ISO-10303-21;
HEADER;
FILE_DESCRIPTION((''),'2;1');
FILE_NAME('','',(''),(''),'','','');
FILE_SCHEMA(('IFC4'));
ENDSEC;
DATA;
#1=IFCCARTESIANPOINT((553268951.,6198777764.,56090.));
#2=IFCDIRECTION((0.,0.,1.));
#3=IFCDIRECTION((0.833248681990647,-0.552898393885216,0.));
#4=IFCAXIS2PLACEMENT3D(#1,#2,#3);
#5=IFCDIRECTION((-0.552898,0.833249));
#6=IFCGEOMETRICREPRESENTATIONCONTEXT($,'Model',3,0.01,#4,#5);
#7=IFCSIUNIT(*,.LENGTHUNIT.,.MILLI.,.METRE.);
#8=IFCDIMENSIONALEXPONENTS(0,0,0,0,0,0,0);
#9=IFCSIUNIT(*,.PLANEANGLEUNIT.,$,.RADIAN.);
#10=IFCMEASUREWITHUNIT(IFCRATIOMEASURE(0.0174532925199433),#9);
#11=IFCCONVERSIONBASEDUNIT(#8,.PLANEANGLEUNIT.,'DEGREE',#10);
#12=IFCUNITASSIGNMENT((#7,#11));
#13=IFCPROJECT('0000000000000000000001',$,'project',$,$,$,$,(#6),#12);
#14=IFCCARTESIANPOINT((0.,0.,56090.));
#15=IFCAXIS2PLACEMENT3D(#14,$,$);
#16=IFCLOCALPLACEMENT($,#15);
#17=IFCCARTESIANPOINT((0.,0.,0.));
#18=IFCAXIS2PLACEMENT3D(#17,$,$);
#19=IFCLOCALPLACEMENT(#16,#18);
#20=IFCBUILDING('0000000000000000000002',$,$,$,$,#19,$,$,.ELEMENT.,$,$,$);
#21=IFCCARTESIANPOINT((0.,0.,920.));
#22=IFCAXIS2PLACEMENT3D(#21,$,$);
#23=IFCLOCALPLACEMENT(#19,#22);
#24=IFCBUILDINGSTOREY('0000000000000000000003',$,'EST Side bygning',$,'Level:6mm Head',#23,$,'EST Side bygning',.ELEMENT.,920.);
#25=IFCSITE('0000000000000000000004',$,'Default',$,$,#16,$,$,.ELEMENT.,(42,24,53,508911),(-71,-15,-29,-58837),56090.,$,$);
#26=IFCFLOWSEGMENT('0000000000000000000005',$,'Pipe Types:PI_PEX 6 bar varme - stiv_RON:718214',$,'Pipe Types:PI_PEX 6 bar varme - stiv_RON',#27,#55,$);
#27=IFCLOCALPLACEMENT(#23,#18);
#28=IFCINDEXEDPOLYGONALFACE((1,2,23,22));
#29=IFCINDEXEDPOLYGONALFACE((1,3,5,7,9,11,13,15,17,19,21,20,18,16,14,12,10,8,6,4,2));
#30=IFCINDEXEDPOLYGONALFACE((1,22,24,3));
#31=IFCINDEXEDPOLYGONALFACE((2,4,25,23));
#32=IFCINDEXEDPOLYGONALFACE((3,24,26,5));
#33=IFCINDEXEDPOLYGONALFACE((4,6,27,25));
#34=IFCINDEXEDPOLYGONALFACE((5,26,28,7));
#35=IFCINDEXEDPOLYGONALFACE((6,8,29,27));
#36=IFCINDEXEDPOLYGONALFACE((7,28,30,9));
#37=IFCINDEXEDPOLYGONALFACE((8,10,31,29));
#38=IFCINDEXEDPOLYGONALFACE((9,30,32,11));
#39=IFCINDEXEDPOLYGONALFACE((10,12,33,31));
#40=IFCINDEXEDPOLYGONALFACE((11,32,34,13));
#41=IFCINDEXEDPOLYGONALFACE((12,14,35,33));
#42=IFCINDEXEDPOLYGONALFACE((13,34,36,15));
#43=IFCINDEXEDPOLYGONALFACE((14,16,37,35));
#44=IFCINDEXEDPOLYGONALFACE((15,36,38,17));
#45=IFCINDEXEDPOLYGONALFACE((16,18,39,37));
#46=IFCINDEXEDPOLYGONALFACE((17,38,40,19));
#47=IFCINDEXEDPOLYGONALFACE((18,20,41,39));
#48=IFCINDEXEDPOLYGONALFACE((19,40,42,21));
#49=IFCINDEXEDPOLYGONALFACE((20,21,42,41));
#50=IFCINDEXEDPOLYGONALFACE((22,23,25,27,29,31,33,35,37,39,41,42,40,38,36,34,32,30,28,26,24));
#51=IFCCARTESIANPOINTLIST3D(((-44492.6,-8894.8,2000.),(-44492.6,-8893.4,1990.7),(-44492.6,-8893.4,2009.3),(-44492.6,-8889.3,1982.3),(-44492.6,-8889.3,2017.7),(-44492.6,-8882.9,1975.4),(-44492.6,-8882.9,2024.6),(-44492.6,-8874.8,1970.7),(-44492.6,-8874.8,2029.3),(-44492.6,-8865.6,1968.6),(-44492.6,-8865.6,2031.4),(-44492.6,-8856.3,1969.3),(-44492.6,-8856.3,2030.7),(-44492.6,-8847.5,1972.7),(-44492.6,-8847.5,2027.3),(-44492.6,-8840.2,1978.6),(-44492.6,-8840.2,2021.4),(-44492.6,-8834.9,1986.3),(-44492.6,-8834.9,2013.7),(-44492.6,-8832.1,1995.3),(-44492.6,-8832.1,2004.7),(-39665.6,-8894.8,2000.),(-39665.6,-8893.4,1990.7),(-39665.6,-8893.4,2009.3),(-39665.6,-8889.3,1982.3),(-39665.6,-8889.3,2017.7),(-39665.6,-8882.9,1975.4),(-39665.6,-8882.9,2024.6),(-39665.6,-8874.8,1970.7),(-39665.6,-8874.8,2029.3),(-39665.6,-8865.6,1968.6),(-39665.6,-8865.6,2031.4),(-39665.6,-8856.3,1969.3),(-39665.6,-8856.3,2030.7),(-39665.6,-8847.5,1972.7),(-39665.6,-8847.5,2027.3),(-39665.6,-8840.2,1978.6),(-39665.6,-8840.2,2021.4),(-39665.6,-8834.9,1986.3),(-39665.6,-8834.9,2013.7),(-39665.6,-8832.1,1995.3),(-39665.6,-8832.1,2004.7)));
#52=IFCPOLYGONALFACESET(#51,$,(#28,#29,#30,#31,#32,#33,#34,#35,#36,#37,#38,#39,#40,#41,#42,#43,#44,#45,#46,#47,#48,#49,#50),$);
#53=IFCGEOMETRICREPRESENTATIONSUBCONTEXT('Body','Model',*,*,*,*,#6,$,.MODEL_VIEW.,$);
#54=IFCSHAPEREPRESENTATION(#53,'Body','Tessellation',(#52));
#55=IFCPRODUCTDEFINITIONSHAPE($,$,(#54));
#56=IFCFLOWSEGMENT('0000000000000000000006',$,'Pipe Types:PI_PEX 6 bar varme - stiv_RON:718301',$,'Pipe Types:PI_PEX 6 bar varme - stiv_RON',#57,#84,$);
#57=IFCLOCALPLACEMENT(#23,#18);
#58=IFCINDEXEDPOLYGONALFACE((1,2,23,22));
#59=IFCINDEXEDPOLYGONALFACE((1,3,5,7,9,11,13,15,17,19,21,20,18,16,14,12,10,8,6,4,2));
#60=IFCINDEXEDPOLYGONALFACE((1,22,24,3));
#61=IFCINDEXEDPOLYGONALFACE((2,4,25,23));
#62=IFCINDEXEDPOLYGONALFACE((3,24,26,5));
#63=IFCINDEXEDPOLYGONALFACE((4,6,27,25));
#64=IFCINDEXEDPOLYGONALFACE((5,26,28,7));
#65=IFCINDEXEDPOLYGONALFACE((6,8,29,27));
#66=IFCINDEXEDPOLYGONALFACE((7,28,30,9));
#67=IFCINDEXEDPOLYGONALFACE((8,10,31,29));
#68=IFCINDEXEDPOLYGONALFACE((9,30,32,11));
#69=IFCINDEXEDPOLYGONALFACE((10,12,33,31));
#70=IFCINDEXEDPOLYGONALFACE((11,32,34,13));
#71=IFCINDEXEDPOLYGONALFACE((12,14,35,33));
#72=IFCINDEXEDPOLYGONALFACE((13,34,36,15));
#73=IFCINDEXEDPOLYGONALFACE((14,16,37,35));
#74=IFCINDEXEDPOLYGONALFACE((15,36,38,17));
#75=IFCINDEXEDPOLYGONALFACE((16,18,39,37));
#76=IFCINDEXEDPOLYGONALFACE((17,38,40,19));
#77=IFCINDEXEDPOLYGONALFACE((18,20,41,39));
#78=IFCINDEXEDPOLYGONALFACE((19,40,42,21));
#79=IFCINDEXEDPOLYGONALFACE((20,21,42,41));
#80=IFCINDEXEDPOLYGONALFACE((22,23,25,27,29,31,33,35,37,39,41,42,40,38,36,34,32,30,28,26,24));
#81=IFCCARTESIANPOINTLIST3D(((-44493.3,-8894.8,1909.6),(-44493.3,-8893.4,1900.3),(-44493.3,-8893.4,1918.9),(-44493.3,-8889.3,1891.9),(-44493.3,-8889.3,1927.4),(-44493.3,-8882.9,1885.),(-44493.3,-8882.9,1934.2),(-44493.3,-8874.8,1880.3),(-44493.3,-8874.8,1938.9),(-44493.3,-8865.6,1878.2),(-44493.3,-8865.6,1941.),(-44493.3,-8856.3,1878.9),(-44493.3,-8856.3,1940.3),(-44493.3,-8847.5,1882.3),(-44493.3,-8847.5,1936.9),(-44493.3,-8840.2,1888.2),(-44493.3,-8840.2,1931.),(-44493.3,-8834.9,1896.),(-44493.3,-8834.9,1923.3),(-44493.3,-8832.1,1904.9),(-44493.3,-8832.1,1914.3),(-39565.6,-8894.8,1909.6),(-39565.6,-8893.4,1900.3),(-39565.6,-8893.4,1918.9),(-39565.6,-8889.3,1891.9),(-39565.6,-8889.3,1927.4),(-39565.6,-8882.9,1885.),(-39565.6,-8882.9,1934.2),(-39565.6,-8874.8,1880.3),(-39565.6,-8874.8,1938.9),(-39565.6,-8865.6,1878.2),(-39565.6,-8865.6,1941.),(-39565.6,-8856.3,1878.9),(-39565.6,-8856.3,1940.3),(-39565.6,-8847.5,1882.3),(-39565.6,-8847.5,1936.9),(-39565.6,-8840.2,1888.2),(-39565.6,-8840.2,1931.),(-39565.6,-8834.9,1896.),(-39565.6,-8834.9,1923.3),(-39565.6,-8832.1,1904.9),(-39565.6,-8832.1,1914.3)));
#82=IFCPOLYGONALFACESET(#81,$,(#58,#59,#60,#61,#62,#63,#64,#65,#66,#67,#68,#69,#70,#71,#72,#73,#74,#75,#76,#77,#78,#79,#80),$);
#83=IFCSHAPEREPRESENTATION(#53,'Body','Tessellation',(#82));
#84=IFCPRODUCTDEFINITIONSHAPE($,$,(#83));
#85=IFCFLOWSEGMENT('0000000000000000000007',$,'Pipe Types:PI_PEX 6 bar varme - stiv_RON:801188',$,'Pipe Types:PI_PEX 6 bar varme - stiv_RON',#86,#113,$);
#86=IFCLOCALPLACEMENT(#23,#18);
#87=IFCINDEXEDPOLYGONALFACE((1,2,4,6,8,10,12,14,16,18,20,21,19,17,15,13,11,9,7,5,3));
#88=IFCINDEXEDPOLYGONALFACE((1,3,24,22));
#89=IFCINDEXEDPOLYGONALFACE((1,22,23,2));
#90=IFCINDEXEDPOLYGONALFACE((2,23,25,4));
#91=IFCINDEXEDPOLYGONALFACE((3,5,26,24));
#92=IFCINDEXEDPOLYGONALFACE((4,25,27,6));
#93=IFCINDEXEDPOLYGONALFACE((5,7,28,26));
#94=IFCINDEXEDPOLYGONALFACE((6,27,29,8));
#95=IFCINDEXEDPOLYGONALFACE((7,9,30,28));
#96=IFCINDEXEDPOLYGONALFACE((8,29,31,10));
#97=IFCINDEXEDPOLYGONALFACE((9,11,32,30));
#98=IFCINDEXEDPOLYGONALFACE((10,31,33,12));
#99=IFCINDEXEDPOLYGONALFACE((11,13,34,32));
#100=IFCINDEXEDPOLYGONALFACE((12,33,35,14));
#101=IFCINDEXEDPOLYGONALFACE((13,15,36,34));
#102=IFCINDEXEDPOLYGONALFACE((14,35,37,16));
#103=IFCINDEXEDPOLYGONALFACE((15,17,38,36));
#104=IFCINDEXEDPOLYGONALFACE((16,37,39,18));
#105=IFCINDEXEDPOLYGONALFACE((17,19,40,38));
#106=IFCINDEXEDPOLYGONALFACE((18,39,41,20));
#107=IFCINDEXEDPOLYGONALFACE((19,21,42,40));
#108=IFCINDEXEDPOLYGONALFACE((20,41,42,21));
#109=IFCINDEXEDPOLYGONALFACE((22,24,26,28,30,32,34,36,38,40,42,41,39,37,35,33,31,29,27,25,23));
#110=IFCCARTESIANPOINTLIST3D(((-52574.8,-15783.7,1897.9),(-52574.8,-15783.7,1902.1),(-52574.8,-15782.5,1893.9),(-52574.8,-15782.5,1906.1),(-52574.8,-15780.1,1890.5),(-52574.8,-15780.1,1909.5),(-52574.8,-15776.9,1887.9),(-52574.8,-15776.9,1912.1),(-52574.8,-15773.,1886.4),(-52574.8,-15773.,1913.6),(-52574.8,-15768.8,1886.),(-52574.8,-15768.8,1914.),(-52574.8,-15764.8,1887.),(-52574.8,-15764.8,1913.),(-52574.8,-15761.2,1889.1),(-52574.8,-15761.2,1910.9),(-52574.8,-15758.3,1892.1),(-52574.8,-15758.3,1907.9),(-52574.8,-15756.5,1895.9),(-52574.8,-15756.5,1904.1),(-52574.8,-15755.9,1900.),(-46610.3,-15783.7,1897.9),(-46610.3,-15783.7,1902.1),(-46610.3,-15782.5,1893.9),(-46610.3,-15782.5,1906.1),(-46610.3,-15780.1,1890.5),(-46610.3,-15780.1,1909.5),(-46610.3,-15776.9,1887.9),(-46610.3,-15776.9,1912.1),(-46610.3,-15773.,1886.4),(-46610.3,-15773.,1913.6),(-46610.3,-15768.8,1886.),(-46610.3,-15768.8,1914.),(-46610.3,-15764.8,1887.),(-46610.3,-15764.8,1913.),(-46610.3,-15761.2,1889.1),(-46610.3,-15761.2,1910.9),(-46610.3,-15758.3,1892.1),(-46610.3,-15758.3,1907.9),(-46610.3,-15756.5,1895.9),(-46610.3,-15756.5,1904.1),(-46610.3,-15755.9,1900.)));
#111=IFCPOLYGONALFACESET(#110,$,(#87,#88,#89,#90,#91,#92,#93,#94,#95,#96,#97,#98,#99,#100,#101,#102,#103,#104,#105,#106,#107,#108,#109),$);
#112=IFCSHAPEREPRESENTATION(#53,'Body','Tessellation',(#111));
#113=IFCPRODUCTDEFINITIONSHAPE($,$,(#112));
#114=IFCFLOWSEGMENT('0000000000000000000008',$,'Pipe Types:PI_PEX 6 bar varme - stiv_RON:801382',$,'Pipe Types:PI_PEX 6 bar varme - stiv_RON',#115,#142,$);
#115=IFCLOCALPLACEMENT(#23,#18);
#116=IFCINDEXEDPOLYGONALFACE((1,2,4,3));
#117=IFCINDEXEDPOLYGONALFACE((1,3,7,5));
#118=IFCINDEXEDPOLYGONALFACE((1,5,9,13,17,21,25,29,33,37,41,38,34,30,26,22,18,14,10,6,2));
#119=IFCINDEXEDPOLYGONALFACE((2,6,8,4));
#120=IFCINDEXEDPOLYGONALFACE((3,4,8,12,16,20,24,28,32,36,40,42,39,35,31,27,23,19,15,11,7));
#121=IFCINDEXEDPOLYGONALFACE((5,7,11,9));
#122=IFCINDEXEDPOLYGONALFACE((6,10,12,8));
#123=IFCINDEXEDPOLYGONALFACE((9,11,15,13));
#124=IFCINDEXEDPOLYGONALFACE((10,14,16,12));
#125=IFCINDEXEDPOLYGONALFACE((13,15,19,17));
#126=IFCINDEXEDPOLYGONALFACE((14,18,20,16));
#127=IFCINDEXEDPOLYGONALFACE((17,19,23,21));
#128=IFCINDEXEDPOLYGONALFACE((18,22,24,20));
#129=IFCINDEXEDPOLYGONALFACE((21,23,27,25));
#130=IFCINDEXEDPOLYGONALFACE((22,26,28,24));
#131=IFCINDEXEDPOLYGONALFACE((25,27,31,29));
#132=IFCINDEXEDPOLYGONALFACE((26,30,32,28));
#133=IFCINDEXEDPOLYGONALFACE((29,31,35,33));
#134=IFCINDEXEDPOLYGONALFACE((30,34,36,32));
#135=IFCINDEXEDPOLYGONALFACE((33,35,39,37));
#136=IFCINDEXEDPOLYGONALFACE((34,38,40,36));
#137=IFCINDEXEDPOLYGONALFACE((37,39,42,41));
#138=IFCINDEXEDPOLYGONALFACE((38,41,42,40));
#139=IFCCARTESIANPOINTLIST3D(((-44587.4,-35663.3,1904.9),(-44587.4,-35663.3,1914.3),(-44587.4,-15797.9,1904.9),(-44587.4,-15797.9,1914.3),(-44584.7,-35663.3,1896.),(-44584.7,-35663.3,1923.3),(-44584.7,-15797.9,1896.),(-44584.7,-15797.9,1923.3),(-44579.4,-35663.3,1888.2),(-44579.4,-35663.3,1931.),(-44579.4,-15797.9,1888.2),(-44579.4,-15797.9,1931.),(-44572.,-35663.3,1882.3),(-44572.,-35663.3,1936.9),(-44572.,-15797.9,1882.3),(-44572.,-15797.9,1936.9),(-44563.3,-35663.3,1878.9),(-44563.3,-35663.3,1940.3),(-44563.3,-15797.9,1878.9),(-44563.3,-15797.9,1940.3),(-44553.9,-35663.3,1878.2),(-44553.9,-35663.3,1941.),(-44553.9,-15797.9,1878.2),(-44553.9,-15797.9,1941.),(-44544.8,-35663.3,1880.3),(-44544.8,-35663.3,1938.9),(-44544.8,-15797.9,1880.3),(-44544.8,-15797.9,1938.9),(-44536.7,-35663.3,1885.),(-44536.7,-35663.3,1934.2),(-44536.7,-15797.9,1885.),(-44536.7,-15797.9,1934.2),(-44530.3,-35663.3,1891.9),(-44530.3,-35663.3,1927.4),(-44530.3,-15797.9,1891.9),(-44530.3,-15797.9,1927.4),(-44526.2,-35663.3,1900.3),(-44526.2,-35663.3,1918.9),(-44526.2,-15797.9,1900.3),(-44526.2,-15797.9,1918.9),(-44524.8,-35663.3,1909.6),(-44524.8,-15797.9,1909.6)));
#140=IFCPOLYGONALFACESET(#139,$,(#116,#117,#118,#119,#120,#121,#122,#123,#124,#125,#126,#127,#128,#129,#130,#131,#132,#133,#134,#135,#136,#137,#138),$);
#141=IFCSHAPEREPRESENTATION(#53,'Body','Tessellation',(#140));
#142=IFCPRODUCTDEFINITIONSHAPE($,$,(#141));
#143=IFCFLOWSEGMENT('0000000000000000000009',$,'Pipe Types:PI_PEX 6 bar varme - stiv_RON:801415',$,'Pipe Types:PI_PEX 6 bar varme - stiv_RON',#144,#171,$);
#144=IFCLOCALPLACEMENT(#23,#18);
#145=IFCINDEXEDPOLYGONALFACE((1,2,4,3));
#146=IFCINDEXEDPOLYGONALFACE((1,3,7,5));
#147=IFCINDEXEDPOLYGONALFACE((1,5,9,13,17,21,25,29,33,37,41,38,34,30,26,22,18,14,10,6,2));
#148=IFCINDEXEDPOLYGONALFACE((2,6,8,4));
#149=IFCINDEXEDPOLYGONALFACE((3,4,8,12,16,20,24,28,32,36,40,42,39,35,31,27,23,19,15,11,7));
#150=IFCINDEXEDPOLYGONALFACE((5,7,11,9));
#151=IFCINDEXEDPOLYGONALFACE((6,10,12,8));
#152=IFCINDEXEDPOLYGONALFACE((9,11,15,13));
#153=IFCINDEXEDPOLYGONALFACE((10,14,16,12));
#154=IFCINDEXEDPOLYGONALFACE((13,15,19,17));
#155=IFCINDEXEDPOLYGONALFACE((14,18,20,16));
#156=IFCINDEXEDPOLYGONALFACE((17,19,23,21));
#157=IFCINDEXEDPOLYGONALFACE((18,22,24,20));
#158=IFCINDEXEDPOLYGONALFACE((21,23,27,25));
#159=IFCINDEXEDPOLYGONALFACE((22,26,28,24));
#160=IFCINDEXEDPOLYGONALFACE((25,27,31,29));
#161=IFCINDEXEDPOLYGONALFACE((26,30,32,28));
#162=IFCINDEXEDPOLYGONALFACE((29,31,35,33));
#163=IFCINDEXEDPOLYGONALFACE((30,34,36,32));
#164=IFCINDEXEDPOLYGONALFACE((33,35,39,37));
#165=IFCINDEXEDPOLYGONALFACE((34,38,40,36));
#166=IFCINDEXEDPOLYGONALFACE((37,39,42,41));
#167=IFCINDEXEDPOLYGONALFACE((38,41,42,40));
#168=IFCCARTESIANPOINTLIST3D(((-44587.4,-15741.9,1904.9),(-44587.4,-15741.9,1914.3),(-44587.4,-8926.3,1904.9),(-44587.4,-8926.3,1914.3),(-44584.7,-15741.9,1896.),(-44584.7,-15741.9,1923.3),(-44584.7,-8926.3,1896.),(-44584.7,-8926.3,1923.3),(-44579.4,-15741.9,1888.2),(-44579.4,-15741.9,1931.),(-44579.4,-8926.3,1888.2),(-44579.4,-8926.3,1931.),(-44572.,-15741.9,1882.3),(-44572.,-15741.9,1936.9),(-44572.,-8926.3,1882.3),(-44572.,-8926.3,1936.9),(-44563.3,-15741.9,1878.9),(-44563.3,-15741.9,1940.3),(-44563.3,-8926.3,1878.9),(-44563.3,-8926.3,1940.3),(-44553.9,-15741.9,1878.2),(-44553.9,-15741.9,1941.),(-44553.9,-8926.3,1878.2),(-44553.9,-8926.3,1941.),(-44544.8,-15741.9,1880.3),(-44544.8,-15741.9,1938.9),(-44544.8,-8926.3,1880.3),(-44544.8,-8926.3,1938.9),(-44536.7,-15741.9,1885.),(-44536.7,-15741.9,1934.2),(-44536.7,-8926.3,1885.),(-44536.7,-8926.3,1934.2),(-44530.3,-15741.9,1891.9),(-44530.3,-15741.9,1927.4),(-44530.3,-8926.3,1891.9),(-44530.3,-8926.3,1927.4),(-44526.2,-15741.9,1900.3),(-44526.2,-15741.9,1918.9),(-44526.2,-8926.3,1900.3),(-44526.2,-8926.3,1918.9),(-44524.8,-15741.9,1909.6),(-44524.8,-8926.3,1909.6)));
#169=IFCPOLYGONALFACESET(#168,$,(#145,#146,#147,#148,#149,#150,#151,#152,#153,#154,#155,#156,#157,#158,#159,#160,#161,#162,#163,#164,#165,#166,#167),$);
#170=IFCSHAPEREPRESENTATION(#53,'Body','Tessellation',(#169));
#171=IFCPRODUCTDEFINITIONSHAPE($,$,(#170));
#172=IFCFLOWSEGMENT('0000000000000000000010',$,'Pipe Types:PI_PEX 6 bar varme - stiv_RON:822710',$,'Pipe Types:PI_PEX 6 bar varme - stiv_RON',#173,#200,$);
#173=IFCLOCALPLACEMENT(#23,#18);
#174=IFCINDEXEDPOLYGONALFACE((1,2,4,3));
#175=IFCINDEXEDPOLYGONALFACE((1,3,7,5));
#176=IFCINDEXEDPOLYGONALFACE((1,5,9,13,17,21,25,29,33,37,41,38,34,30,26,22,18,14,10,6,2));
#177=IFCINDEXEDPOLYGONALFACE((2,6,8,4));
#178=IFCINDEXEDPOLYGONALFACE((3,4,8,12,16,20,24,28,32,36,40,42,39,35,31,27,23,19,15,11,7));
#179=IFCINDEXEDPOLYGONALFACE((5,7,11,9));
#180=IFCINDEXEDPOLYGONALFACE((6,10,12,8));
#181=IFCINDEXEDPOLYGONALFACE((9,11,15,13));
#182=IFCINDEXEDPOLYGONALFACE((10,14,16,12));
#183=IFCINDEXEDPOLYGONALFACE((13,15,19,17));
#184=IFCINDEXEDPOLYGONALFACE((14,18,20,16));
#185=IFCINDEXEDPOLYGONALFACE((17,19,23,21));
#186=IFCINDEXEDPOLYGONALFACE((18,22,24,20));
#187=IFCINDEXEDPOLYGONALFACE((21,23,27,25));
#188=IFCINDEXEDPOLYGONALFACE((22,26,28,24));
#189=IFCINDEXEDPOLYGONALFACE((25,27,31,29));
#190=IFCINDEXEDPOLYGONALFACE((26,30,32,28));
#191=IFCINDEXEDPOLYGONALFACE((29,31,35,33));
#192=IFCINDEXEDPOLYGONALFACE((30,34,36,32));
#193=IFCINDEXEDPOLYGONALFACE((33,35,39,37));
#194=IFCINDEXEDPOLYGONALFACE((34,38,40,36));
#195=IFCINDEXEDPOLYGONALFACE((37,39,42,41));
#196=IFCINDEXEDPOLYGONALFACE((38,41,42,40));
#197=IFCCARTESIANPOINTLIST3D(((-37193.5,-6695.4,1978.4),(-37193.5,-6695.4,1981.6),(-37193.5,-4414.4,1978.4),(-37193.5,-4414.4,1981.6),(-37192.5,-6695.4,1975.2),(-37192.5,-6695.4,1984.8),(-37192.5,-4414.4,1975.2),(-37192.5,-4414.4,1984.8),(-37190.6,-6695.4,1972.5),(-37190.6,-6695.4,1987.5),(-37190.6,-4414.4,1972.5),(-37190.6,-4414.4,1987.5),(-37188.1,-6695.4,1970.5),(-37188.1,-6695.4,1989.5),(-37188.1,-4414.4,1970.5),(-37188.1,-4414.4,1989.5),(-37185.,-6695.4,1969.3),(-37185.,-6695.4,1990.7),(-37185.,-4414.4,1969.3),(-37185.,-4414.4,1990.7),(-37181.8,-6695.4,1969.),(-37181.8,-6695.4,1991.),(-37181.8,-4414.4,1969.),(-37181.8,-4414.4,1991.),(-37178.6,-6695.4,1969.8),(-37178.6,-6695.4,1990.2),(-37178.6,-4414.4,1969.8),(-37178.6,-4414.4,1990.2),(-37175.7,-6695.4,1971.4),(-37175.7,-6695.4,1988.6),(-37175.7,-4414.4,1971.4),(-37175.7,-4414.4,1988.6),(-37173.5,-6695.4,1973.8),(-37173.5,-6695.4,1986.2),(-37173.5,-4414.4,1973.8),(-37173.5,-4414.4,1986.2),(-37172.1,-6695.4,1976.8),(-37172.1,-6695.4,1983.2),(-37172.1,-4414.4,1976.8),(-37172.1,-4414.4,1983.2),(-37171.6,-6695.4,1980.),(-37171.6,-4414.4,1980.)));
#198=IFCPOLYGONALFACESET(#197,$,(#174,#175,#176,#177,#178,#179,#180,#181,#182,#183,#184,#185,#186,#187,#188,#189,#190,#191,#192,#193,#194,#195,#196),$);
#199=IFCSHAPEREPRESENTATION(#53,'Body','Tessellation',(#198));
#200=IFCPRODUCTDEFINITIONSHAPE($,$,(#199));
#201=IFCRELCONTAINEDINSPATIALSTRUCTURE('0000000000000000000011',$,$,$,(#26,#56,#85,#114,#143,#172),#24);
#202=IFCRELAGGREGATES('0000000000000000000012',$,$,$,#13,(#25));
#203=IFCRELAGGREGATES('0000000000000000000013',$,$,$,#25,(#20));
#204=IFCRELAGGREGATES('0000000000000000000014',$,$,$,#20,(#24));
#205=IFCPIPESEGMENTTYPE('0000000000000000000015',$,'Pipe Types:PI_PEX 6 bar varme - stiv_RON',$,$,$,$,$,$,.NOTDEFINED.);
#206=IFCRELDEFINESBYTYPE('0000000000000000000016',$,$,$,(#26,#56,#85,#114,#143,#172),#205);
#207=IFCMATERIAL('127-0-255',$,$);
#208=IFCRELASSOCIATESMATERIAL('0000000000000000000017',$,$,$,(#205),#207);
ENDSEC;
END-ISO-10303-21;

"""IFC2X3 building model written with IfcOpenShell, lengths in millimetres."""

from ifc_helpers import new_model, entity, si_unit, converted_unit, direction, frame, frame_2d, origin, origin_2d_with_axis, place, context, subcontext, project, spatial, circle, extrude, material, type_object, element, save


model = new_model("IFC2X3")

# Units and contexts
model_context = context("Model", 3, precision=0.01, world=frame((553268951.0, 6198777764.0, 56090.0), z_axis=(0.0, 0.0, 1.0), x_axis=(0.833248681990647, -0.552898393885216, 0.0)), true_north=direction((-0.552898, 0.833249)))
body_context = subcontext(model_context, "Body", "Model", "MODEL_VIEW")
ifc_project = project(units=[si_unit("LENGTHUNIT", "METRE", prefix="MILLI"), converted_unit("PLANEANGLEUNIT", "DEGREE", entity("IfcRatioMeasure", 0.0174532925199433), si_unit("PLANEANGLEUNIT", "RADIAN"), dimensions=[0, 0, 0, 0, 0, 0, 0])], contexts=[model_context])

# Site, building, storey
site_placement = place(None, frame((0.0, 0.0, 56090.0)))
site = spatial("IfcSite", under=ifc_project, at=site_placement, Name="Default", CompositionType="ELEMENT", RefLatitude=(42, 24, 53, 508911), RefLongitude=(-71, -15, -29, -58837), RefElevation=56090.0)
building_placement = place(site_placement, origin())
building = spatial("IfcBuilding", under=site, at=building_placement, CompositionType="ELEMENT")
storey_placement = place(building_placement, frame((0.0, 0.0, 920.0)))
storey = spatial("IfcBuildingStorey", under=building, at=storey_placement, Name="EST Side bygning", ObjectType="Level:6mm Head", LongName="EST Side bygning", CompositionType="ELEMENT", Elevation=920.0)

# Flow segments
ifc_material_1 = material(Name="127-0-255")
pipe_segment_type_1 = type_object("IfcPipeSegmentType", Name="Pipe Types:PI_PEX 6 bar varme - stiv_RON", PredefinedType="NOTDEFINED", material=ifc_material_1)
flow_segment_1_placement = place(storey_placement, origin())
element("IfcFlowSegment", 1, at=flow_segment_1_placement, inside=storey, type_object=pipe_segment_type_1, Name="Pipe Types:PI_PEX 6 bar varme - stiv_RON:718214", ObjectType="Pipe Types:PI_PEX 6 bar varme - stiv_RON", context=body_context, shape_type="SweptSolid", body=[
    extrude(circle(Radius=31.5, at=frame_2d((0.0, 0.0), x_axis=(1.0, 0.0))), frame((-44492.6, -8863.3, 2000.0), z_axis=(1.0, 0.0, 0.0), x_axis=(0.0, -1.0, 0.0)), (0.0, 0.0, 1.0), 4827.0),
])
flow_segment_2_placement = place(storey_placement, origin())
element("IfcFlowSegment", 2, at=flow_segment_2_placement, inside=storey, type_object=pipe_segment_type_1, Name="Pipe Types:PI_PEX 6 bar varme - stiv_RON:718301", ObjectType="Pipe Types:PI_PEX 6 bar varme - stiv_RON", context=body_context, shape_type="SweptSolid", body=[
    extrude(circle(Radius=31.5, at=frame_2d((0.0, 0.0), x_axis=(1.0, 0.0))), frame((-44493.3, -8863.3, 1909.6), z_axis=(1.0, 0.0, 0.0), x_axis=(0.0, -1.0, 0.0)), (0.0, 0.0, 1.0), 4927.7),
])
flow_segment_3_placement = place(storey_placement, origin())
element("IfcFlowSegment", 3, at=flow_segment_3_placement, inside=storey, type_object=pipe_segment_type_1, Name="Pipe Types:PI_PEX 6 bar varme - stiv_RON:801188", ObjectType="Pipe Types:PI_PEX 6 bar varme - stiv_RON", context=body_context, shape_type="SweptSolid", body=[
    extrude(circle(Radius=14.0, at=origin_2d_with_axis()), frame((-52574.8, -15769.9, 1900.0), z_axis=(1.0, 0.0, 0.0), x_axis=(0.0, 1.0, 0.0)), (0.0, 0.0, 1.0), 5964.5),
])
flow_segment_4_placement = place(storey_placement, origin())
element("IfcFlowSegment", 4, at=flow_segment_4_placement, inside=storey, type_object=pipe_segment_type_1, Name="Pipe Types:PI_PEX 6 bar varme - stiv_RON:801382", ObjectType="Pipe Types:PI_PEX 6 bar varme - stiv_RON", context=body_context, shape_type="SweptSolid", body=[
    extrude(circle(Radius=31.5, at=origin_2d_with_axis()), frame((-44556.3, -35663.3, 1909.6), z_axis=(0.0, 1.0, 0.0), x_axis=(1.0, 0.0, 0.0)), (0.0, 0.0, 1.0), 19865.4),
])
flow_segment_5_placement = place(storey_placement, origin())
element("IfcFlowSegment", 5, at=flow_segment_5_placement, inside=storey, type_object=pipe_segment_type_1, Name="Pipe Types:PI_PEX 6 bar varme - stiv_RON:801415", ObjectType="Pipe Types:PI_PEX 6 bar varme - stiv_RON", context=body_context, shape_type="SweptSolid", body=[
    extrude(circle(Radius=31.5, at=origin_2d_with_axis()), frame((-44556.3, -15741.9, 1909.6), z_axis=(0.0, 1.0, 0.0), x_axis=(1.0, 0.0, 0.0)), (0.0, 0.0, 1.0), 6815.6),
])
flow_segment_6_placement = place(storey_placement, origin())
element("IfcFlowSegment", 6, at=flow_segment_6_placement, inside=storey, type_object=pipe_segment_type_1, Name="Pipe Types:PI_PEX 6 bar varme - stiv_RON:822710", ObjectType="Pipe Types:PI_PEX 6 bar varme - stiv_RON", context=body_context, shape_type="SweptSolid", body=[
    extrude(circle(Radius=11.0, at=origin_2d_with_axis()), frame((-37182.6, -6695.4, 1980.0), z_axis=(0.0, 1.0, 0.0), x_axis=(1.0, 0.0, 0.0)), (0.0, 0.0, 1.0), 2281.0),
])

save(model, "model.ifc")
